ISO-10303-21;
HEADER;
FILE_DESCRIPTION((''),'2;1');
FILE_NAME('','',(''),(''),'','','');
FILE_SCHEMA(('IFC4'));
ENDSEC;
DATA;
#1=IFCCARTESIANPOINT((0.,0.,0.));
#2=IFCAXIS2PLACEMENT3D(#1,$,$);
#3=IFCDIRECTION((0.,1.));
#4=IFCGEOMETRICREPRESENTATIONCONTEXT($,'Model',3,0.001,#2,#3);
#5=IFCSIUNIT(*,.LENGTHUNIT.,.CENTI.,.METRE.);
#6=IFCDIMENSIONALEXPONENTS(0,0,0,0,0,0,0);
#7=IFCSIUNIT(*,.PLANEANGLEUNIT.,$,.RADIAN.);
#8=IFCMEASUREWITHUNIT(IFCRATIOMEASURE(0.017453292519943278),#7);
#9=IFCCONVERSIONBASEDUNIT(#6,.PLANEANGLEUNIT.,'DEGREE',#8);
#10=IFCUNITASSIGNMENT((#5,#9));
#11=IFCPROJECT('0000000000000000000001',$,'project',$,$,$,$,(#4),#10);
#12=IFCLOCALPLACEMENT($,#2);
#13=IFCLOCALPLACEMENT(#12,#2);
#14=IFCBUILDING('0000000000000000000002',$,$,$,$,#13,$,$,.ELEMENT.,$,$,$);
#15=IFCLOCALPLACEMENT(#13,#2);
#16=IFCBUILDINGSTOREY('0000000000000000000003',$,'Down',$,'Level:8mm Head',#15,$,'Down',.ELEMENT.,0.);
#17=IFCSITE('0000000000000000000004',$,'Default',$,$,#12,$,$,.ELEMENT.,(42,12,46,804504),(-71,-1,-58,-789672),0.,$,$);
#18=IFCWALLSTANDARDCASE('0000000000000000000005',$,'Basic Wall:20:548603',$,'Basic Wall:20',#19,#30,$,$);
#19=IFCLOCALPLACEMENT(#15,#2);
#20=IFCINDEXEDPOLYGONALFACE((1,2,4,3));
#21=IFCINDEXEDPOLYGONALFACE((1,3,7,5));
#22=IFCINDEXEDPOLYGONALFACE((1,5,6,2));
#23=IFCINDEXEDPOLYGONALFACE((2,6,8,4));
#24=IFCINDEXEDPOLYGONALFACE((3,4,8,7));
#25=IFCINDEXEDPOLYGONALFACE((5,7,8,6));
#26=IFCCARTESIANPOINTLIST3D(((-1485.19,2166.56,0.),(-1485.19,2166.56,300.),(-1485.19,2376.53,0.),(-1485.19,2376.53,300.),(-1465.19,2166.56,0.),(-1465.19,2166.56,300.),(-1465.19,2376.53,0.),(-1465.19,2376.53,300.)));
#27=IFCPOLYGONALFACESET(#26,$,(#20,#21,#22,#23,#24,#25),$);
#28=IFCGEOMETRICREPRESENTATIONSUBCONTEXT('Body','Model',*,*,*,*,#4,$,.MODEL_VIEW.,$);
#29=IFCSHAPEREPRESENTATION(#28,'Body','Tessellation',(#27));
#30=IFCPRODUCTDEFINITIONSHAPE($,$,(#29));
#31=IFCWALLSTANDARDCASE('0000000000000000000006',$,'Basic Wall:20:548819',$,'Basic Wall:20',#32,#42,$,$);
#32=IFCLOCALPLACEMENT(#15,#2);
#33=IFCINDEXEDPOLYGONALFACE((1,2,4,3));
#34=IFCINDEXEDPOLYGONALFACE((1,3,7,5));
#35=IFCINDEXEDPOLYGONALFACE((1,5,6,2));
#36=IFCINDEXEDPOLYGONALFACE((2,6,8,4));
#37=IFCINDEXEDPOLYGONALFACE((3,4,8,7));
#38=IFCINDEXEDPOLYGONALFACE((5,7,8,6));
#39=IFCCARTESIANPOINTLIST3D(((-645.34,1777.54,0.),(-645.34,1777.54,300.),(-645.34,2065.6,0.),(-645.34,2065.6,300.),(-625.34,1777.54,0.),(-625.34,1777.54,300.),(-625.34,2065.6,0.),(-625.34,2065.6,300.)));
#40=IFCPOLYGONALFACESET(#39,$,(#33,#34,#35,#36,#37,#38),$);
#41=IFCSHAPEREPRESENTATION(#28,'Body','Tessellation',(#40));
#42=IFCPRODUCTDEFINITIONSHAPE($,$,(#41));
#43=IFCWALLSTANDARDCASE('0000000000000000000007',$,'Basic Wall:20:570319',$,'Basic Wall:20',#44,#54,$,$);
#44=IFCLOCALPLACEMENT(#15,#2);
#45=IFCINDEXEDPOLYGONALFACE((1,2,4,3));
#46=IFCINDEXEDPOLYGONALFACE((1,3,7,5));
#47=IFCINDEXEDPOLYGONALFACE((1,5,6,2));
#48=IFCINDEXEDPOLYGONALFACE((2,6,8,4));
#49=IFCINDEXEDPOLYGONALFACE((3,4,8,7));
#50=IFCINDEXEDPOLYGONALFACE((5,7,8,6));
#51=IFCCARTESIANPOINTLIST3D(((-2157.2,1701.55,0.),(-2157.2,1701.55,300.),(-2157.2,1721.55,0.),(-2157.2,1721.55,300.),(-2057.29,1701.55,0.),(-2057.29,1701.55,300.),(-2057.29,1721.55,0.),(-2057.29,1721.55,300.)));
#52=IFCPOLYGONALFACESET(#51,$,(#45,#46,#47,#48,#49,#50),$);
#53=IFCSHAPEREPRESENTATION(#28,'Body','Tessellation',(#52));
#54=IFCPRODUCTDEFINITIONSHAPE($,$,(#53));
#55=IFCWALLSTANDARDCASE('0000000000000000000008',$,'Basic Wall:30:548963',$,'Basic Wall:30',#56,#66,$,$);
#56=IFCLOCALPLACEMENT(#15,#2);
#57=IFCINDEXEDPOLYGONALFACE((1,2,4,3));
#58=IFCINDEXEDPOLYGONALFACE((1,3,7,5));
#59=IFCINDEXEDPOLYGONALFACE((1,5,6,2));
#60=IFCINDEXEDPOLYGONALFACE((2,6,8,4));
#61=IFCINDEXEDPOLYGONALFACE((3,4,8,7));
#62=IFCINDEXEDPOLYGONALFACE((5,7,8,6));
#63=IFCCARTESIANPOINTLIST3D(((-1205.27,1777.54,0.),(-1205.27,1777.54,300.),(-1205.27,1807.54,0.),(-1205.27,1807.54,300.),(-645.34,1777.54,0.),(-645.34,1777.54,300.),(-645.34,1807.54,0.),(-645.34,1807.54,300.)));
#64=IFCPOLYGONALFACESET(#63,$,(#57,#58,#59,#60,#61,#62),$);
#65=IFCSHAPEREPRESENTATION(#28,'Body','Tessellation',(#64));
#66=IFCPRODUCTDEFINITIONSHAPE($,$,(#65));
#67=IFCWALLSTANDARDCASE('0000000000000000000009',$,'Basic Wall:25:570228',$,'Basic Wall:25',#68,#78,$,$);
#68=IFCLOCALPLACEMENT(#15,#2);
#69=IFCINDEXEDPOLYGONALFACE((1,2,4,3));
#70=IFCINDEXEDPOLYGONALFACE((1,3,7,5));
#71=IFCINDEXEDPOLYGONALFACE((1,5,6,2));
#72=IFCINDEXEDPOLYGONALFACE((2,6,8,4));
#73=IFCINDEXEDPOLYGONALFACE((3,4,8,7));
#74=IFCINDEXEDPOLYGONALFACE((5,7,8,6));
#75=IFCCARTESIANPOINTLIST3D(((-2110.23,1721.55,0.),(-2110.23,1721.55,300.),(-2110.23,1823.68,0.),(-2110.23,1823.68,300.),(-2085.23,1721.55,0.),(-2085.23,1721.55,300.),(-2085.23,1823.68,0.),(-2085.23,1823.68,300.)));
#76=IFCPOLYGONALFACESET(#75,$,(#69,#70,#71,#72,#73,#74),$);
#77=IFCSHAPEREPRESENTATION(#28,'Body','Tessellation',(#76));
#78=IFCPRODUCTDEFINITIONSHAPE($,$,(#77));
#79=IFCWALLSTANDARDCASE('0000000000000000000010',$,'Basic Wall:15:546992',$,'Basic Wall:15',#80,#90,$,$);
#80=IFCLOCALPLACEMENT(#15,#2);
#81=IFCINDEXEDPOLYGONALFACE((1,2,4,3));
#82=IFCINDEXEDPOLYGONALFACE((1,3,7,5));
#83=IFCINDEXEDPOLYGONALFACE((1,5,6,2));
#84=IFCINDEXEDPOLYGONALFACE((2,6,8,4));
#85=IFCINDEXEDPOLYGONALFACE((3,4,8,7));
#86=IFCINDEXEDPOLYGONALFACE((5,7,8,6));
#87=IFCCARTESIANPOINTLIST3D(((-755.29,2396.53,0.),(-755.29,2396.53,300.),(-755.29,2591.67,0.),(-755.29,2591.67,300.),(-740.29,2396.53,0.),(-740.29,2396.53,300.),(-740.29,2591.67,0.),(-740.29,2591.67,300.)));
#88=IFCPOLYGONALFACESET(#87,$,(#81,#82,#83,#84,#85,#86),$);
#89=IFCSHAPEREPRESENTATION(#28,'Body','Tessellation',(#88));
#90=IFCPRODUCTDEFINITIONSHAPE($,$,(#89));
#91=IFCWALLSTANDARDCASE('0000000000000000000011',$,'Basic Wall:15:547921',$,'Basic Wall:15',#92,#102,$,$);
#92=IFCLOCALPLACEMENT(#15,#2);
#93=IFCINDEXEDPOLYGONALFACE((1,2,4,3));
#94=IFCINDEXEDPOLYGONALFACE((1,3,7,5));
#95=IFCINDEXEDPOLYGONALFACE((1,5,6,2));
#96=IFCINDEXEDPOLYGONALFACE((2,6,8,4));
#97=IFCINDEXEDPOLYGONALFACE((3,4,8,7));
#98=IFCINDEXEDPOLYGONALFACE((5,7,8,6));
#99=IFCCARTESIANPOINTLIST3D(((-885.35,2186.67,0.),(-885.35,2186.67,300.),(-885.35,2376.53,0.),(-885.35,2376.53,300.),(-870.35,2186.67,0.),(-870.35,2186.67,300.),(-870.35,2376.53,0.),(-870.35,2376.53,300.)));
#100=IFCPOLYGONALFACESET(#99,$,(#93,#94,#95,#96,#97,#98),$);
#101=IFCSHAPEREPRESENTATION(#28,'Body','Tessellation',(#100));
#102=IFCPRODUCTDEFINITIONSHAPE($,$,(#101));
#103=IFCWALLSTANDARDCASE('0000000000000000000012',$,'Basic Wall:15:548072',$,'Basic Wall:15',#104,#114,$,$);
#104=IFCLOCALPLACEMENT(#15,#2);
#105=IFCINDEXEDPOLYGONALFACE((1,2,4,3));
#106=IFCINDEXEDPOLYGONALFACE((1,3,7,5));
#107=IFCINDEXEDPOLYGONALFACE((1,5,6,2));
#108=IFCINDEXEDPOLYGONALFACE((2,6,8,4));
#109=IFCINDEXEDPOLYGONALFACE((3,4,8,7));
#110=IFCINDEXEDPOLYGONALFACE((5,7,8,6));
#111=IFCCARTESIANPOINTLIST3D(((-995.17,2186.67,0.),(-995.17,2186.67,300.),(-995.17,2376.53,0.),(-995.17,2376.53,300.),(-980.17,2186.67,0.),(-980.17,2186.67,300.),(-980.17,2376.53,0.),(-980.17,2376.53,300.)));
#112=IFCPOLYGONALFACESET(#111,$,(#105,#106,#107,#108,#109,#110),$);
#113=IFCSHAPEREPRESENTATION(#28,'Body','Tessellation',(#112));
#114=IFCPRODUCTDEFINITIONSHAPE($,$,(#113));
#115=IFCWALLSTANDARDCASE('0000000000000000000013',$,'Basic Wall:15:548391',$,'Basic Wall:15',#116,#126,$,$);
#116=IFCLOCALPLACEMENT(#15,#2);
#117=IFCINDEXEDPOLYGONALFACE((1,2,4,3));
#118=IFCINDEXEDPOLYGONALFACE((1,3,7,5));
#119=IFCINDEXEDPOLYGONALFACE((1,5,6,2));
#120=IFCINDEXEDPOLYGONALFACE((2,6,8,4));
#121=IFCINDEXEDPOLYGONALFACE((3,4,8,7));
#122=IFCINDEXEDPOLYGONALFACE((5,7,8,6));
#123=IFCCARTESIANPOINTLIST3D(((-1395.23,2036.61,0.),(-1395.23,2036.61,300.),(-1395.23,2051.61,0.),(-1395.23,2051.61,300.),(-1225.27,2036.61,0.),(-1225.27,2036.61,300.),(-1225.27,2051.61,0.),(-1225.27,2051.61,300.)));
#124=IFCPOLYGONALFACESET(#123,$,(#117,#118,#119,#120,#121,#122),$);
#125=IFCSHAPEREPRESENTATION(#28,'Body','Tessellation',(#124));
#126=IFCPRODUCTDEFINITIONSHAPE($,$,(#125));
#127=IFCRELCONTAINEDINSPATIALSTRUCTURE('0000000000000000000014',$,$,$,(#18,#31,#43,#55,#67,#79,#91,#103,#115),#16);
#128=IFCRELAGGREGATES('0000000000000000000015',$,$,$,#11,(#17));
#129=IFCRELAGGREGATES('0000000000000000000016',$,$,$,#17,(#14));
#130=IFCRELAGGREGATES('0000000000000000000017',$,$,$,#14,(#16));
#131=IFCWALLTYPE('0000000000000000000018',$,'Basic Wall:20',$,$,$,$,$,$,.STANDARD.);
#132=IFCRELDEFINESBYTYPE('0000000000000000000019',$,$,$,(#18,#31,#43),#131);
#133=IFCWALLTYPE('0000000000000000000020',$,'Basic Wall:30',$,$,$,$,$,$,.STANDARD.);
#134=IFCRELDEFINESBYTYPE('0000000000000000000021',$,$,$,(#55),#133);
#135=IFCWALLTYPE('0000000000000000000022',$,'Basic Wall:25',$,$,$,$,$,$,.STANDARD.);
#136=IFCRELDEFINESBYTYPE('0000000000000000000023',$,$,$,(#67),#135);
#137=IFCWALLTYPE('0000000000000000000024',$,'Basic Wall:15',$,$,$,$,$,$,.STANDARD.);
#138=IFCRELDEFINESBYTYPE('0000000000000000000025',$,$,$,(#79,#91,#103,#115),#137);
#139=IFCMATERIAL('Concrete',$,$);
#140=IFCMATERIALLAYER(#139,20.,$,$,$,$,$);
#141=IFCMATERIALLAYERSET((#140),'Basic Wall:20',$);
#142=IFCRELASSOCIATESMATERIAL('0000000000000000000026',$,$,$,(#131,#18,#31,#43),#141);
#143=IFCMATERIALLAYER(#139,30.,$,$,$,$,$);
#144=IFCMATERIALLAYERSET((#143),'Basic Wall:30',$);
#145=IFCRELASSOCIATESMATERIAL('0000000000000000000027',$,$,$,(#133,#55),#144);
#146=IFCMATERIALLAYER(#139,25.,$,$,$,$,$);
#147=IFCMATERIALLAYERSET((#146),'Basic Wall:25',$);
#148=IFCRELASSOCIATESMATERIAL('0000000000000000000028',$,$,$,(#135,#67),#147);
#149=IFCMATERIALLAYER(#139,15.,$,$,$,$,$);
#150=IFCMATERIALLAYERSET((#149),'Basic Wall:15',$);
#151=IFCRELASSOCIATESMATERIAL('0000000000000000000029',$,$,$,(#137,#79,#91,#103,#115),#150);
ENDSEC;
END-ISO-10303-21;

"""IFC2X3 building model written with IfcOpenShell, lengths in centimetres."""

from ifc_helpers import new_model, entity, si_unit, converted_unit, direction, frame, frame_2d, origin, place, context, subcontext, project, spatial, rectangle, extrude, material, layer, layer_set, layer_usage, type_object, element, save


model = new_model("IFC2X3")

# Units and contexts
model_context = context("Model", 3, precision=0.001, world=origin(), true_north=direction((0.0, 1.0)))
body_context = subcontext(model_context, "Body", "Model", "MODEL_VIEW")
ifc_project = project(units=[si_unit("LENGTHUNIT", "METRE", prefix="CENTI"), converted_unit("PLANEANGLEUNIT", "DEGREE", entity("IfcRatioMeasure", 0.017453292519943278), si_unit("PLANEANGLEUNIT", "RADIAN"), dimensions=[0, 0, 0, 0, 0, 0, 0])], contexts=[model_context])

# Site, building, storey
site_placement = place(None, origin())
site = spatial("IfcSite", under=ifc_project, at=site_placement, Name="Default", CompositionType="ELEMENT", RefLatitude=(42, 12, 46, 804504), RefLongitude=(-71, -1, -58, -789672), RefElevation=0.0)
building_placement = place(site_placement, origin())
building = spatial("IfcBuilding", under=site, at=building_placement, CompositionType="ELEMENT")
storey_placement = place(building_placement, origin())
storey = spatial("IfcBuildingStorey", under=building, at=storey_placement, Name="Down", ObjectType="Level:8mm Head", LongName="Down", CompositionType="ELEMENT", Elevation=0.0)

# Walls
ifc_material = material(Name="Concrete")
ifc_layer_1 = layer(ifc_material, 20.0)
ifc_layer_set_1 = layer_set([ifc_layer_1], Name="Basic Wall:20")
wall_type_1 = type_object("IfcWallType", Name="Basic Wall:20", PredefinedType="STANDARD", material=ifc_layer_set_1)
ifc_layer_usage_1 = layer_usage(ifc_layer_set_1, "AXIS2", "NEGATIVE", 10.0)
wall_1_placement = place(storey_placement, frame((-1475.19, 2166.56, 0.0), z_axis=(0.0, 0.0, 1.0), x_axis=(0.0, 1.0, 0.0)))
element("IfcWallStandardCase", 1, at=wall_1_placement, inside=storey, type_object=wall_type_1, material=ifc_layer_usage_1, Name="Basic Wall:20:548603", ObjectType="Basic Wall:20", context=body_context, shape_type="SweptSolid", body=[
    extrude(rectangle(XDim=209.97, YDim=20.0, at=frame_2d((104.98, 0.0), x_axis=(-1.0, 0.0))), origin(), (0.0, 0.0, 1.0), 300.0),
])
ifc_layer_usage_2 = layer_usage(ifc_layer_set_1, "AXIS2", "POSITIVE", -10.0)
wall_2_placement = place(storey_placement, frame((-635.34, 2065.6, 0.0), z_axis=(0.0, 0.0, 1.0), x_axis=(0.0, -1.0, 0.0)))
element("IfcWallStandardCase", 2, at=wall_2_placement, inside=storey, type_object=wall_type_1, material=ifc_layer_usage_2, Name="Basic Wall:20:548819", ObjectType="Basic Wall:20", context=body_context, shape_type="SweptSolid", body=[
    extrude(rectangle(XDim=288.07, YDim=20.0, at=frame_2d((144.03, 0.0), x_axis=(-1.0, 0.0))), origin(), (0.0, 0.0, 1.0), 300.0),
])
ifc_layer_usage_3 = layer_usage(ifc_layer_set_1, "AXIS2", "POSITIVE", -10.0)
wall_3_placement = place(storey_placement, frame((-2057.29, 1711.55, 0.0), z_axis=(0.0, 0.0, 1.0), x_axis=(-1.0, 0.0, 0.0)))
element("IfcWallStandardCase", 3, at=wall_3_placement, inside=storey, type_object=wall_type_1, material=ifc_layer_usage_3, Name="Basic Wall:20:570319", ObjectType="Basic Wall:20", context=body_context, shape_type="SweptSolid", body=[
    extrude(rectangle(XDim=99.9, YDim=20.0, at=frame_2d((49.95, 0.0), x_axis=(-1.0, 0.0))), origin(), (0.0, 0.0, 1.0), 300.0),
])
ifc_layer_2 = layer(ifc_material, 30.0)
ifc_layer_set_2 = layer_set([ifc_layer_2], Name="Basic Wall:30")
ifc_layer_usage_4 = layer_usage(ifc_layer_set_2, "AXIS2", "NEGATIVE", 15.0)
wall_type_2 = type_object("IfcWallType", Name="Basic Wall:30", PredefinedType="STANDARD", material=ifc_layer_set_2)
wall_4_placement = place(storey_placement, frame((-645.34, 1792.54, 0.0), z_axis=(0.0, 0.0, 1.0), x_axis=(-1.0, 0.0, 0.0)))
element("IfcWallStandardCase", 4, at=wall_4_placement, inside=storey, type_object=wall_type_2, material=ifc_layer_usage_4, Name="Basic Wall:30:548963", ObjectType="Basic Wall:30", context=body_context, shape_type="SweptSolid", body=[
    extrude(rectangle(XDim=559.94, YDim=30.0, at=frame_2d((279.97, 0.0), x_axis=(-1.0, 0.0))), origin(), (0.0, 0.0, 1.0), 300.0),
])
ifc_layer_3 = layer(ifc_material, 25.0)
ifc_layer_set_3 = layer_set([ifc_layer_3], Name="Basic Wall:25")
ifc_layer_usage_5 = layer_usage(ifc_layer_set_3, "AXIS2", "NEGATIVE", 12.5)
wall_type_3 = type_object("IfcWallType", Name="Basic Wall:25", PredefinedType="STANDARD", material=ifc_layer_set_3)
wall_5_placement = place(storey_placement, frame((-2097.73, 1823.68, 0.0), z_axis=(0.0, 0.0, 1.0), x_axis=(0.0, -1.0, 0.0)))
element("IfcWallStandardCase", 5, at=wall_5_placement, inside=storey, type_object=wall_type_3, material=ifc_layer_usage_5, Name="Basic Wall:25:570228", ObjectType="Basic Wall:25", context=body_context, shape_type="SweptSolid", body=[
    extrude(rectangle(XDim=102.13, YDim=25.0, at=frame_2d((51.06, 0.0), x_axis=(-1.0, 0.0))), origin(), (0.0, 0.0, 1.0), 300.0),
])
ifc_layer_4 = layer(ifc_material, 15.0)
ifc_layer_set_4 = layer_set([ifc_layer_4], Name="Basic Wall:15")
ifc_layer_usage_6 = layer_usage(ifc_layer_set_4, "AXIS2", "POSITIVE", -7.5)
wall_type_4 = type_object("IfcWallType", Name="Basic Wall:15", PredefinedType="STANDARD", material=ifc_layer_set_4)
wall_6_placement = place(storey_placement, frame((-747.79, 2591.67, 0.0), z_axis=(0.0, 0.0, 1.0), x_axis=(0.0, -1.0, 0.0)))
element("IfcWallStandardCase", 6, at=wall_6_placement, inside=storey, type_object=wall_type_4, material=ifc_layer_usage_6, Name="Basic Wall:15:546992", ObjectType="Basic Wall:15", context=body_context, shape_type="SweptSolid", body=[
    extrude(rectangle(XDim=195.15, YDim=15.0, at=frame_2d((97.57, 0.0), x_axis=(-1.0, 0.0))), origin(), (0.0, 0.0, 1.0), 300.0),
])
ifc_layer_usage_7 = layer_usage(ifc_layer_set_4, "AXIS2", "POSITIVE", -7.5)
wall_7_placement = place(storey_placement, frame((-877.85, 2376.53, 0.0), z_axis=(0.0, 0.0, 1.0), x_axis=(0.0, -1.0, 0.0)))
element("IfcWallStandardCase", 7, at=wall_7_placement, inside=storey, type_object=wall_type_4, material=ifc_layer_usage_7, Name="Basic Wall:15:547921", ObjectType="Basic Wall:15", context=body_context, shape_type="SweptSolid", body=[
    extrude(rectangle(XDim=189.86, YDim=15.0, at=frame_2d((94.93, 0.0), x_axis=(-1.0, 0.0))), origin(), (0.0, 0.0, 1.0), 300.0),
])
ifc_layer_usage_8 = layer_usage(ifc_layer_set_4, "AXIS2", "POSITIVE", -7.5)
wall_8_placement = place(storey_placement, frame((-987.67, 2186.67, 0.0), z_axis=(0.0, 0.0, 1.0), x_axis=(0.0, 1.0, 0.0)))
element("IfcWallStandardCase", 8, at=wall_8_placement, inside=storey, type_object=wall_type_4, material=ifc_layer_usage_8, Name="Basic Wall:15:548072", ObjectType="Basic Wall:15", context=body_context, shape_type="SweptSolid", body=[
    extrude(rectangle(XDim=189.86, YDim=15.0, at=frame_2d((94.93, 0.0), x_axis=(-1.0, 0.0))), origin(), (0.0, 0.0, 1.0), 300.0),
])
ifc_layer_usage_9 = layer_usage(ifc_layer_set_4, "AXIS2", "POSITIVE", -7.5)
wall_9_placement = place(storey_placement, frame((-1395.23, 2044.11, 0.0)))
element("IfcWallStandardCase", 9, at=wall_9_placement, inside=storey, type_object=wall_type_4, material=ifc_layer_usage_9, Name="Basic Wall:15:548391", ObjectType="Basic Wall:15", context=body_context, shape_type="SweptSolid", body=[
    extrude(rectangle(XDim=169.96, YDim=15.0, at=frame_2d((84.98, 0.0), x_axis=(-1.0, 0.0))), origin(), (0.0, 0.0, 1.0), 300.0),
])

save(model, "model.ifc")
